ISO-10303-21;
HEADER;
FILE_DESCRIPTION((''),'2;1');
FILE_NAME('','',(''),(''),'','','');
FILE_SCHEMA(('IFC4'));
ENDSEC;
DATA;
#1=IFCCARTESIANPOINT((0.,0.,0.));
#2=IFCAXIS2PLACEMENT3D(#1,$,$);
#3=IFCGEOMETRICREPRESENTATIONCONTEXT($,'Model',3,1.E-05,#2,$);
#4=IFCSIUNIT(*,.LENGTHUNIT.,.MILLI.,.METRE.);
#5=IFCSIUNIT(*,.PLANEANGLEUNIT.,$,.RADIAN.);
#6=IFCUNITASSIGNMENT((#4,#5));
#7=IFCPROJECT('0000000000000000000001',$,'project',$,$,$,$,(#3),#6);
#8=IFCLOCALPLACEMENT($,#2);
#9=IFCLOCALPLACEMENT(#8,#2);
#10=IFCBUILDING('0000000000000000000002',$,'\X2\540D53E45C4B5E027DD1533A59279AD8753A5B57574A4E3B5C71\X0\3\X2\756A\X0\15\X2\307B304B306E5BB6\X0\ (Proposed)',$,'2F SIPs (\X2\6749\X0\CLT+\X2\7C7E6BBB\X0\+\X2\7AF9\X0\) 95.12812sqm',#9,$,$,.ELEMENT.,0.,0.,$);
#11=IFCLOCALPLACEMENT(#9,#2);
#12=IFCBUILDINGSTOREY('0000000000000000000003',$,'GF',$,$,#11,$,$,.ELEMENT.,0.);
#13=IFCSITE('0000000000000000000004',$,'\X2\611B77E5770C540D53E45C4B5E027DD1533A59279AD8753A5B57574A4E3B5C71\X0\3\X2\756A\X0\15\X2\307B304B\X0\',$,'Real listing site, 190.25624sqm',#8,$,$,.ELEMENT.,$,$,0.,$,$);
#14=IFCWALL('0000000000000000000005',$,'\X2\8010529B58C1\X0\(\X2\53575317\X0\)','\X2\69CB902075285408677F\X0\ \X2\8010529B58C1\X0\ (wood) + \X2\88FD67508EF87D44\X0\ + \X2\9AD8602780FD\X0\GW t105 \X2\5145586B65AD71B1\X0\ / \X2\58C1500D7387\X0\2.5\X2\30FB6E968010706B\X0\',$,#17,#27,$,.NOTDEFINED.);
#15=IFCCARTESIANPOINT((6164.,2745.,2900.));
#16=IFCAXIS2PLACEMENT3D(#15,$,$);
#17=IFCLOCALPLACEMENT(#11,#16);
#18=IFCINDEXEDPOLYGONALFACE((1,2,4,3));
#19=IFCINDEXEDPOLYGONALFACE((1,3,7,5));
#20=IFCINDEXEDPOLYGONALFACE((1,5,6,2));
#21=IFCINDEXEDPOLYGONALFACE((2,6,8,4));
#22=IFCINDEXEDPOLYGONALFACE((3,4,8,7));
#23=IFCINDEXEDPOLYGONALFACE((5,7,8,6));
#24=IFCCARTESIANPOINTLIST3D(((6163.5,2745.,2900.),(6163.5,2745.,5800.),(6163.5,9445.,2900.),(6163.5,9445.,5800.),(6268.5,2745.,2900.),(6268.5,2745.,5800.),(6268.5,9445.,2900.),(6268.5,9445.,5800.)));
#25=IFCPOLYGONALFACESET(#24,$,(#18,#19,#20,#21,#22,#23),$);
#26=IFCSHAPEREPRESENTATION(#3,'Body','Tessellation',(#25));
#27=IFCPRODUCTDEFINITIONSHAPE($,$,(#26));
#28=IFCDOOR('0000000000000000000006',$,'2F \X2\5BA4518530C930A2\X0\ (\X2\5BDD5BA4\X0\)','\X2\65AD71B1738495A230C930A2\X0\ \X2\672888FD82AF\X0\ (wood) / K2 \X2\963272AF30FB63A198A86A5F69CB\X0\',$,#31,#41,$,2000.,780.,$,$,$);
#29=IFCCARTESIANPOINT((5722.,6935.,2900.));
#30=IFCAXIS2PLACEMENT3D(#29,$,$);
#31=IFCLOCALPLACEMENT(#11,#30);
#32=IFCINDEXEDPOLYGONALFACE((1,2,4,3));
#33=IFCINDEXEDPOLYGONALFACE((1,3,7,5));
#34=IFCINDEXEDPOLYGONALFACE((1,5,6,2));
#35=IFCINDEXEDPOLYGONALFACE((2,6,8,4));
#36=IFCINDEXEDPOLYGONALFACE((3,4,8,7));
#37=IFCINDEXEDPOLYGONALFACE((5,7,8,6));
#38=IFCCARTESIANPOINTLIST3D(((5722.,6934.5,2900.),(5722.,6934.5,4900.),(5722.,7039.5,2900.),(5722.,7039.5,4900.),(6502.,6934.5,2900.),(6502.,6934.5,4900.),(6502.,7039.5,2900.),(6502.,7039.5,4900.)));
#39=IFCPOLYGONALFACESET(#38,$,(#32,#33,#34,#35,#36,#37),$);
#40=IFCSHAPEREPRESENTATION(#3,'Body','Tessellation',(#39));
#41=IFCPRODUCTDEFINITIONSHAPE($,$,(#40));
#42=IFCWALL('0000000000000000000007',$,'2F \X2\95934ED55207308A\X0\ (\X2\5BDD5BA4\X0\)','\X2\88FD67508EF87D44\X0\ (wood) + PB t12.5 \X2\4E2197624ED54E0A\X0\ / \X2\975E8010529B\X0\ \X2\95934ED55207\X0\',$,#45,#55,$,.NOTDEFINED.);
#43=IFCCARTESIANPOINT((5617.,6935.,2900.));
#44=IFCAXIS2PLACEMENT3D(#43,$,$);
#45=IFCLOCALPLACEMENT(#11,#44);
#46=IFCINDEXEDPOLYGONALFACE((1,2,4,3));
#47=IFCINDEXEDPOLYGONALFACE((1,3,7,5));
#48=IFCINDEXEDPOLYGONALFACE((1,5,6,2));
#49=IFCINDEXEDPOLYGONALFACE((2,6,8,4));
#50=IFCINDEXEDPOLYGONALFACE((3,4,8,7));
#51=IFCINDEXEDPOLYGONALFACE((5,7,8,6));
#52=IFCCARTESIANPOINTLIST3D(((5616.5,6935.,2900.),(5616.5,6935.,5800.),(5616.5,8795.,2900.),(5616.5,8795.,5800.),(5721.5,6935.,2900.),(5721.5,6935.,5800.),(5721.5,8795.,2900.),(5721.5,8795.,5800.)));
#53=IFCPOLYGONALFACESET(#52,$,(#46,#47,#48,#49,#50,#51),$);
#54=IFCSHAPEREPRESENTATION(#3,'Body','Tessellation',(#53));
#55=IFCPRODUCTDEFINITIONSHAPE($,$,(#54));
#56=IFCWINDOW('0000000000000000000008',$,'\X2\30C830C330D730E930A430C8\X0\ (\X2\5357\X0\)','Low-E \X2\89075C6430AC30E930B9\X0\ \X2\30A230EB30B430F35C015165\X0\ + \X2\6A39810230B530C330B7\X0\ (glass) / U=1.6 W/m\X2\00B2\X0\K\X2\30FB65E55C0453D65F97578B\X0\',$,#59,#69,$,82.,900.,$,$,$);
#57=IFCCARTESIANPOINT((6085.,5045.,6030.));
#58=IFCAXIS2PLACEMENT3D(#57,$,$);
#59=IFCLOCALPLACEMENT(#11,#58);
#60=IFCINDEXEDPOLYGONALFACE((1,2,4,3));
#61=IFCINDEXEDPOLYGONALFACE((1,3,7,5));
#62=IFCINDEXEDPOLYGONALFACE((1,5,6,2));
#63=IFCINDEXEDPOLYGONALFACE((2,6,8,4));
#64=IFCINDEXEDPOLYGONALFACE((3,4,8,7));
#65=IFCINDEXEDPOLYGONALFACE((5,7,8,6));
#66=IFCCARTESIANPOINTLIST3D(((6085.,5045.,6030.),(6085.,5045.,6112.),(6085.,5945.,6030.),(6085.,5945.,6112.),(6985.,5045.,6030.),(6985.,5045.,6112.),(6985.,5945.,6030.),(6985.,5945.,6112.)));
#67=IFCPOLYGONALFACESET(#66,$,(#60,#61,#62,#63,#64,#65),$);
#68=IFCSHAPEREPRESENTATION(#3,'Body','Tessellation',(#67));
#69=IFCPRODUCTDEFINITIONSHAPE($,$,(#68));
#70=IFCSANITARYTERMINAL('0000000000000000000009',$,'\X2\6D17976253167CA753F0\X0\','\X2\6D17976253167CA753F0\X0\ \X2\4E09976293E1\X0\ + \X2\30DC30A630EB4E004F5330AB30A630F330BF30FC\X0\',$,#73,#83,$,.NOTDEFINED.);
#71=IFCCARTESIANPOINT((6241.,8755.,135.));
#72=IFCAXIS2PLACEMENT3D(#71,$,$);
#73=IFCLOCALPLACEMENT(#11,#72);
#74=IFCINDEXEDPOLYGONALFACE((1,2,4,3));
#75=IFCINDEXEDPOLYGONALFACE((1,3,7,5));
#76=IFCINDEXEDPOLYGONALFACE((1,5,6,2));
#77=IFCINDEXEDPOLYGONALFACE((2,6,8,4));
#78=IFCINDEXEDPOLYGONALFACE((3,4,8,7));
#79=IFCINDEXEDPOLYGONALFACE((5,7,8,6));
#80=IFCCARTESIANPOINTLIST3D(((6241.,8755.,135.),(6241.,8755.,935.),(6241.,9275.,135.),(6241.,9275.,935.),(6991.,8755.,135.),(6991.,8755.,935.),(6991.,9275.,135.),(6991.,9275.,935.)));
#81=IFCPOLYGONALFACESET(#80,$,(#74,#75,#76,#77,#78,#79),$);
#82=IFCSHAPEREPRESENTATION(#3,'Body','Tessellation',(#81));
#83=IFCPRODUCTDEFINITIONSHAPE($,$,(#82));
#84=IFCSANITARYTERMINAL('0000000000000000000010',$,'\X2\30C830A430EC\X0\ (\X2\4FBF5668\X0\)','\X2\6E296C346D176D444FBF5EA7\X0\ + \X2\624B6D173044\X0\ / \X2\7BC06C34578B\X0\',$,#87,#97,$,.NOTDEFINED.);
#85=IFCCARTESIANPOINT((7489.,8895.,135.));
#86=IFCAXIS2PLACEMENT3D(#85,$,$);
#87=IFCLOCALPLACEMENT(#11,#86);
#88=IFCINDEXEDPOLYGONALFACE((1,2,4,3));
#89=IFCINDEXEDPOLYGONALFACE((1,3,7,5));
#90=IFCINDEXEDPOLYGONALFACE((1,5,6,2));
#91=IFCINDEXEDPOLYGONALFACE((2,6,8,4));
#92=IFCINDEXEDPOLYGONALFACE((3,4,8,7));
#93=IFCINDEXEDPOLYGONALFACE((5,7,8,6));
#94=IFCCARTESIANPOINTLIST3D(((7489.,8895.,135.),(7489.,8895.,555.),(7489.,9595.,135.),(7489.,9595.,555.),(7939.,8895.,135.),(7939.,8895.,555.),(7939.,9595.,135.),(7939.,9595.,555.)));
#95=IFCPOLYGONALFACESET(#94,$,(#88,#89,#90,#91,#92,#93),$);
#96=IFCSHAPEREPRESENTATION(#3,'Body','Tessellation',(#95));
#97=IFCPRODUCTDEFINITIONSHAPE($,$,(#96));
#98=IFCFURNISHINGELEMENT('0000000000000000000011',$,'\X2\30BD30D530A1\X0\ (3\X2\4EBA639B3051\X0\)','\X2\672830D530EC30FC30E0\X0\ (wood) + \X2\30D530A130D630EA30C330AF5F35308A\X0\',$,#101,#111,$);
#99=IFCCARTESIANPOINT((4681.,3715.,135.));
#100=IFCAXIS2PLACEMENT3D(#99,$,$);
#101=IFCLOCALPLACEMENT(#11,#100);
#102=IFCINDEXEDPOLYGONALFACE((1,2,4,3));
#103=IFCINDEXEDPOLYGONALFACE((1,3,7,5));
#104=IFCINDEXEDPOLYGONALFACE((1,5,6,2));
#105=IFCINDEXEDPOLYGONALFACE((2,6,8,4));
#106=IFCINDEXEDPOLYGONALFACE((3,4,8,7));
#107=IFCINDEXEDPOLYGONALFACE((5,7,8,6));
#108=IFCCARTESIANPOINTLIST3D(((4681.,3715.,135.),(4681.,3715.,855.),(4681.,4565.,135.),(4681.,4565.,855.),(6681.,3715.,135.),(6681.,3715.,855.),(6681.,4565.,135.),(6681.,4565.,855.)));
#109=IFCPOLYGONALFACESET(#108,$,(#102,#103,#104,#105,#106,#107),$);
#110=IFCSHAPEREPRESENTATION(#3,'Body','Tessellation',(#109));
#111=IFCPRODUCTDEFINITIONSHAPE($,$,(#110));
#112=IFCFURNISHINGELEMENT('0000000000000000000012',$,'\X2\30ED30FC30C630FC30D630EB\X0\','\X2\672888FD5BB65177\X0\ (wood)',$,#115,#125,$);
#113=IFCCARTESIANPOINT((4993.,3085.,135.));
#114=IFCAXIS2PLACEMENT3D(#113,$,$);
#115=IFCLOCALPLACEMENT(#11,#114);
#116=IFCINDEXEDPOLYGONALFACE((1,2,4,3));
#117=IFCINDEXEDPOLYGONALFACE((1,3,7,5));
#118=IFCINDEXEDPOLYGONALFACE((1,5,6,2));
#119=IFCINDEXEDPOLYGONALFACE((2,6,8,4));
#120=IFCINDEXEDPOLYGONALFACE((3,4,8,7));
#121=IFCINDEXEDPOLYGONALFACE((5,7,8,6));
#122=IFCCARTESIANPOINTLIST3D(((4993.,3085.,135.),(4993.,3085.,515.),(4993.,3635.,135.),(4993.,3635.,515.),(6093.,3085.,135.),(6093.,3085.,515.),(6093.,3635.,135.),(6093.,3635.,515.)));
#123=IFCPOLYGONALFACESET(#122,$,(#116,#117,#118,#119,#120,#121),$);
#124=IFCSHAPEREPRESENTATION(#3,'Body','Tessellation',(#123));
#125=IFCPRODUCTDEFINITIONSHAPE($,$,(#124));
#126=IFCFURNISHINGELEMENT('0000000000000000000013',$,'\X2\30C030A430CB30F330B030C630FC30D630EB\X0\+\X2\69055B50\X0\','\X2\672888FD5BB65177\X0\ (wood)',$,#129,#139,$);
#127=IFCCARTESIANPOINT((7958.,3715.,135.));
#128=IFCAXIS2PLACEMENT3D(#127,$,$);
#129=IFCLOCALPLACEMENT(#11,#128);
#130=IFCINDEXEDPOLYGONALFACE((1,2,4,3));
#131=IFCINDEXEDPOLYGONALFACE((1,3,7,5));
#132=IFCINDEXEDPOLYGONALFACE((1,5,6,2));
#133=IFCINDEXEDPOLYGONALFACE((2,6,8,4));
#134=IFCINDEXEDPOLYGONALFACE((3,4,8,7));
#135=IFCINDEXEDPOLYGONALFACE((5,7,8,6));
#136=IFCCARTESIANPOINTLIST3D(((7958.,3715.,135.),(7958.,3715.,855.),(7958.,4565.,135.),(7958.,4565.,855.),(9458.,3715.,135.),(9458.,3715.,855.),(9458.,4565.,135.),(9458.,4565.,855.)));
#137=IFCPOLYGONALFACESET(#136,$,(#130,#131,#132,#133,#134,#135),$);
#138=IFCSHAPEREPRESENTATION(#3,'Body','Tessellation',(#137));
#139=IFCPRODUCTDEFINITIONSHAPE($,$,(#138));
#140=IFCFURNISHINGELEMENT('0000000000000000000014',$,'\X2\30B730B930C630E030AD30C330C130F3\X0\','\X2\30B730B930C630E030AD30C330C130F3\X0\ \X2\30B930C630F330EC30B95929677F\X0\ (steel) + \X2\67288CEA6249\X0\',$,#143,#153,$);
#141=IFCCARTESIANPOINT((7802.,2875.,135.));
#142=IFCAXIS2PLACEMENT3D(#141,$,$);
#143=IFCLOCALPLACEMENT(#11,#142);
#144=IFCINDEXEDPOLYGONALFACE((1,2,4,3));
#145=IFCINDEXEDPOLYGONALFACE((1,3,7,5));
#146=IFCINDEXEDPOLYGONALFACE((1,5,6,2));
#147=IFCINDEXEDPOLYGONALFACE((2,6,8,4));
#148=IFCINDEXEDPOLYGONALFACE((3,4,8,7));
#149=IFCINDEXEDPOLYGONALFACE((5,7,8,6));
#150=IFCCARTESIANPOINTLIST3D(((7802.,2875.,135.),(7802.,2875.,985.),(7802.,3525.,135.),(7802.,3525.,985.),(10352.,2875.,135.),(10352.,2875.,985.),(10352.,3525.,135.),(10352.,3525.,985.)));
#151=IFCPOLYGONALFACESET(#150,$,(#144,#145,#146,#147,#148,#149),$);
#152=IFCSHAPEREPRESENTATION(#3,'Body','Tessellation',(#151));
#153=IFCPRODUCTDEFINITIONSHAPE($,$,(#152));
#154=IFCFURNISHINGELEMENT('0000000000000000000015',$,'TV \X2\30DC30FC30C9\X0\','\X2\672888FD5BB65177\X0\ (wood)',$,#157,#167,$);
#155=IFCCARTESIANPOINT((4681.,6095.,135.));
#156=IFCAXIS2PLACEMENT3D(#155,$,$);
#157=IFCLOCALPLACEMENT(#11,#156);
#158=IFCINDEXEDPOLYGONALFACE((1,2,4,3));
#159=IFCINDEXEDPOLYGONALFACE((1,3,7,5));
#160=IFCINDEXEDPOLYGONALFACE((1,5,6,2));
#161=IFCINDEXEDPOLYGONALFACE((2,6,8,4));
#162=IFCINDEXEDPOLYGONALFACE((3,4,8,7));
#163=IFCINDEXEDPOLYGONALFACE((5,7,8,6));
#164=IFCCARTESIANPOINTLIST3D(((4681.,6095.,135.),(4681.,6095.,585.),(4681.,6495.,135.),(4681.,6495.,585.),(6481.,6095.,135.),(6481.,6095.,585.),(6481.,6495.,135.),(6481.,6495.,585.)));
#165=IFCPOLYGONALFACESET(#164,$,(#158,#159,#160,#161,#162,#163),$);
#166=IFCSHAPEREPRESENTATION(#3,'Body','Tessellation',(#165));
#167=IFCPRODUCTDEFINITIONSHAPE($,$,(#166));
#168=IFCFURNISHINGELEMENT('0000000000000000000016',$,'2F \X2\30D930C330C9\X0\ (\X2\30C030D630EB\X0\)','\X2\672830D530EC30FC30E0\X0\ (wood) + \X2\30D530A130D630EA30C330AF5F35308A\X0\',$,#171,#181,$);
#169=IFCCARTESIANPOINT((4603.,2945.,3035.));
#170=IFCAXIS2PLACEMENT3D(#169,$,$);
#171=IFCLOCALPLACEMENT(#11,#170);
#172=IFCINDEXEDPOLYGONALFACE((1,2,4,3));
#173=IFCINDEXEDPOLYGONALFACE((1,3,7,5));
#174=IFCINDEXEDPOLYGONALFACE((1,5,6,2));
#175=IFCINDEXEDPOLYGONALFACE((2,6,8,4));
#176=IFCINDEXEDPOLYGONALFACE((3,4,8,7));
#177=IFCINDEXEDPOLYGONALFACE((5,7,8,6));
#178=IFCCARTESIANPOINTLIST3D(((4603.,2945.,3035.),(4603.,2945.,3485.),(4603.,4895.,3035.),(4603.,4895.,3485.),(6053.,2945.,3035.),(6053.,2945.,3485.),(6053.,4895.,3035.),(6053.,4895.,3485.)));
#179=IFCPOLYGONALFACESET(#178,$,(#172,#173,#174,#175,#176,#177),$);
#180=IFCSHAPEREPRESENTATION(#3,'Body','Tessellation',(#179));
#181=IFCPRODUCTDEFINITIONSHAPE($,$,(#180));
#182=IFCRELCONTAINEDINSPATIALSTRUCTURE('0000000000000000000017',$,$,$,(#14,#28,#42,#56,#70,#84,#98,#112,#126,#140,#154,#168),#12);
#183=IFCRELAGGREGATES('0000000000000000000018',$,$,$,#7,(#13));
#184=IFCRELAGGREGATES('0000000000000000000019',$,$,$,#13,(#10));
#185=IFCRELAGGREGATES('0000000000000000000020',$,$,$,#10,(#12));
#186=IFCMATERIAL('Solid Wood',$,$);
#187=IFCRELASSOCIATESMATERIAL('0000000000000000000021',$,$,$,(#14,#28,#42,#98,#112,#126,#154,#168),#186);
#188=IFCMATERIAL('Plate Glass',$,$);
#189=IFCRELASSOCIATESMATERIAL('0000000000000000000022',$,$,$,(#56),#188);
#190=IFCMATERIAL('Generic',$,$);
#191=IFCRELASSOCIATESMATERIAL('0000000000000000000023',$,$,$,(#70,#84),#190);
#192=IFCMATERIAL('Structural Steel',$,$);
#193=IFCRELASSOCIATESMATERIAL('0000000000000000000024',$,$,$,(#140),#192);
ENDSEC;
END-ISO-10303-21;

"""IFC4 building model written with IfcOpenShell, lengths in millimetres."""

from ifc_helpers import new_model, si_unit, frame, frame_2d, origin, place, context, project, spatial, rectangle, extrude, material, element, fill, save


model = new_model("IFC4")

# Units and contexts
model_context = context("Model", 3, precision=1e-05, world=origin())
ifc_project = project(units=[si_unit("LENGTHUNIT", "METRE", prefix="MILLI"), si_unit("PLANEANGLEUNIT", "RADIAN")], contexts=[model_context])

# Site, building, storey
site_placement = place(None, origin())
site = spatial("IfcSite", under=ifc_project, at=site_placement, Name="愛知県名古屋市緑区大高町字坊主山3番15ほか", ObjectType="Real listing site, 190.25624sqm", CompositionType="ELEMENT", RefElevation=0.0)
building_placement = place(site_placement, origin())
building = spatial("IfcBuilding", under=site, at=building_placement, Name="名古屋市緑区大高町字坊主山3番15ほかの家 (Proposed)", ObjectType="2F SIPs (杉CLT+籾殻+竹) 95.12812sqm", CompositionType="ELEMENT", ElevationOfRefHeight=0.0, ElevationOfTerrain=0.0)
storey_placement = place(building_placement, origin())
storey = spatial("IfcBuildingStorey", under=building, at=storey_placement, Name="GF", CompositionType="ELEMENT", Elevation=0.0)

# Shared definitions
ifc_material_1 = material(Name="Solid Wood")

# Wall, opening, door
wall_1_placement = place(storey_placement, frame((6164.0, 2745.0, 2900.0)))
wall_1 = element("IfcWall", 1, at=wall_1_placement, inside=storey, material=ifc_material_1, Name="耐力壁(南北)", Description="構造用合板 耐力壁 (wood) + 製材軸組 + 高性能GW t105 充填断熱 / 壁倍率2.5・準耐火", PredefinedType="NOTDEFINED", context=model_context, shape_type="SweptSolid", body=[
    extrude(rectangle(XDim=105.0, YDim=6700.0, at=frame_2d((52.0, 3350.0))), frame((6164.0, 2745.0, 2900.0)), (0.0, 0.0, 1.0), 2900.0),
])
opening_1_placement = place(storey_placement, frame((5722.0, 6935.0, 2900.0)))
opening_1 = element("IfcOpeningElement", 2, at=opening_1_placement, cuts=wall_1, PredefinedType="NOTDEFINED", context=model_context, shape_type="SweptSolid", body=[
    extrude(rectangle(XDim=780.0, YDim=105.0, at=frame_2d((390.0, 52.0))), frame((5722.0, 6935.0, 2900.0)), (0.0, 0.0, 1.0), 2000.0),
])
door_1_placement = place(storey_placement, frame((5722.0, 6935.0, 2900.0)))
door_1 = element("IfcDoor", 3, at=door_1_placement, inside=storey, material=ifc_material_1, Name="2F 室内ドア (寝室)", Description="断熱玄関ドア 木製芯 (wood) / K2 防犯・採風機構", OverallHeight=2000.0, OverallWidth=780.0, context=model_context, shape_type="SweptSolid", body=[
    extrude(rectangle(XDim=780.0, YDim=105.0, at=frame_2d((390.0, 52.0))), frame((5722.0, 6935.0, 2900.0)), (0.0, 0.0, 1.0), 2000.0),
])
fill(opening_1, door_1)

# Wall
wall_2_placement = place(storey_placement, frame((5617.0, 6935.0, 2900.0)))
element("IfcWall", 4, at=wall_2_placement, inside=storey, material=ifc_material_1, Name="2F 間仕切り (寝室)", Description="製材軸組 (wood) + PB t12.5 両面仕上 / 非耐力 間仕切", PredefinedType="NOTDEFINED", context=model_context, shape_type="SweptSolid", body=[
    extrude(rectangle(XDim=105.0, YDim=1860.0, at=frame_2d((52.0, 930.0))), frame((5617.0, 6935.0, 2900.0)), (0.0, 0.0, 1.0), 2900.0),
])

# Window
ifc_material_2 = material(Name="Plate Glass")
window_placement = place(storey_placement, frame((6085.0, 5045.0, 6030.0)))
element("IfcWindow", 5, at=window_placement, inside=storey, material=ifc_material_2, Name="トップライト (南)", Description="Low-E 複層ガラス アルゴン封入 + 樹脂サッシ (glass) / U=1.6 W/m²K・日射取得型", OverallHeight=82.0, OverallWidth=900.0, context=model_context, shape_type="SweptSolid", body=[
    extrude(rectangle(XDim=900.0, YDim=900.0, at=frame_2d((450.0, 450.0))), frame((6085.0, 5045.0, 6030.0)), (0.0, 0.0, 1.0), 82.0),
])

# Sanitary terminals
ifc_material_3 = material(Name="Generic")
sanitary_terminal_1_placement = place(storey_placement, frame((6241.0, 8755.0, 135.0)))
element("IfcSanitaryTerminal", 6, at=sanitary_terminal_1_placement, inside=storey, material=ifc_material_3, Name="洗面化粧台", Description="洗面化粧台 三面鏡 + ボウル一体カウンター", PredefinedType="NOTDEFINED", context=model_context, shape_type="SweptSolid", body=[
    extrude(rectangle(XDim=750.0, YDim=520.0, at=frame_2d((375.0, 260.0))), frame((6241.0, 8755.0, 135.0)), (0.0, 0.0, 1.0), 800.0),
])
sanitary_terminal_2_placement = place(storey_placement, frame((7489.0, 8895.0, 135.0)))
element("IfcSanitaryTerminal", 7, at=sanitary_terminal_2_placement, inside=storey, material=ifc_material_3, Name="トイレ (便器)", Description="温水洗浄便座 + 手洗い / 節水型", PredefinedType="NOTDEFINED", context=model_context, shape_type="SweptSolid", body=[
    extrude(rectangle(XDim=450.0, YDim=700.0, at=frame_2d((225.0, 350.0))), frame((7489.0, 8895.0, 135.0)), (0.0, 0.0, 1.0), 420.0),
])

# Furnishing elements
furnishing_1_placement = place(storey_placement, frame((4681.0, 3715.0, 135.0)))
element("IfcFurnishingElement", 8, at=furnishing_1_placement, inside=storey, material=ifc_material_1, Name="ソファ (3人掛け)", Description="木フレーム (wood) + ファブリック張り", context=model_context, shape_type="SweptSolid", body=[
    extrude(rectangle(XDim=2000.0, YDim=850.0, at=frame_2d((1000.0, 425.0))), frame((4681.0, 3715.0, 135.0)), (0.0, 0.0, 1.0), 720.0),
])
furnishing_2_placement = place(storey_placement, frame((4993.0, 3085.0, 135.0)))
element("IfcFurnishingElement", 9, at=furnishing_2_placement, inside=storey, material=ifc_material_1, Name="ローテーブル", Description="木製家具 (wood)", context=model_context, shape_type="SweptSolid", body=[
    extrude(rectangle(XDim=1100.0, YDim=550.0, at=frame_2d((550.0, 275.0))), frame((4993.0, 3085.0, 135.0)), (0.0, 0.0, 1.0), 380.0),
])
furnishing_3_placement = place(storey_placement, frame((7958.0, 3715.0, 135.0)))
element("IfcFurnishingElement", 10, at=furnishing_3_placement, inside=storey, material=ifc_material_1, Name="ダイニングテーブル+椅子", Description="木製家具 (wood)", context=model_context, shape_type="SweptSolid", body=[
    extrude(rectangle(XDim=1500.0, YDim=850.0, at=frame_2d((750.0, 425.0))), frame((7958.0, 3715.0, 135.0)), (0.0, 0.0, 1.0), 720.0),
])
ifc_material_4 = material(Name="Structural Steel")
furnishing_4_placement = place(storey_placement, frame((7802.0, 2875.0, 135.0)))
element("IfcFurnishingElement", 11, at=furnishing_4_placement, inside=storey, material=ifc_material_4, Name="システムキッチン", Description="システムキッチン ステンレス天板 (steel) + 木質扉", context=model_context, shape_type="SweptSolid", body=[
    extrude(rectangle(XDim=2550.0, YDim=650.0, at=frame_2d((1275.0, 325.0))), frame((7802.0, 2875.0, 135.0)), (0.0, 0.0, 1.0), 850.0),
])
furnishing_5_placement = place(storey_placement, frame((4681.0, 6095.0, 135.0)))
element("IfcFurnishingElement", 12, at=furnishing_5_placement, inside=storey, material=ifc_material_1, Name="TV ボード", Description="木製家具 (wood)", context=model_context, shape_type="SweptSolid", body=[
    extrude(rectangle(XDim=1800.0, YDim=400.0, at=frame_2d((900.0, 200.0))), frame((4681.0, 6095.0, 135.0)), (0.0, 0.0, 1.0), 450.0),
])
furnishing_6_placement = place(storey_placement, frame((4603.0, 2945.0, 3035.0)))
element("IfcFurnishingElement", 13, at=furnishing_6_placement, inside=storey, material=ifc_material_1, Name="2F ベッド (ダブル)", Description="木フレーム (wood) + ファブリック張り", context=model_context, shape_type="SweptSolid", body=[
    extrude(rectangle(XDim=1450.0, YDim=1950.0, at=frame_2d((725.0, 975.0))), frame((4603.0, 2945.0, 3035.0)), (0.0, 0.0, 1.0), 450.0),
])

save(model, "model.ifc")
